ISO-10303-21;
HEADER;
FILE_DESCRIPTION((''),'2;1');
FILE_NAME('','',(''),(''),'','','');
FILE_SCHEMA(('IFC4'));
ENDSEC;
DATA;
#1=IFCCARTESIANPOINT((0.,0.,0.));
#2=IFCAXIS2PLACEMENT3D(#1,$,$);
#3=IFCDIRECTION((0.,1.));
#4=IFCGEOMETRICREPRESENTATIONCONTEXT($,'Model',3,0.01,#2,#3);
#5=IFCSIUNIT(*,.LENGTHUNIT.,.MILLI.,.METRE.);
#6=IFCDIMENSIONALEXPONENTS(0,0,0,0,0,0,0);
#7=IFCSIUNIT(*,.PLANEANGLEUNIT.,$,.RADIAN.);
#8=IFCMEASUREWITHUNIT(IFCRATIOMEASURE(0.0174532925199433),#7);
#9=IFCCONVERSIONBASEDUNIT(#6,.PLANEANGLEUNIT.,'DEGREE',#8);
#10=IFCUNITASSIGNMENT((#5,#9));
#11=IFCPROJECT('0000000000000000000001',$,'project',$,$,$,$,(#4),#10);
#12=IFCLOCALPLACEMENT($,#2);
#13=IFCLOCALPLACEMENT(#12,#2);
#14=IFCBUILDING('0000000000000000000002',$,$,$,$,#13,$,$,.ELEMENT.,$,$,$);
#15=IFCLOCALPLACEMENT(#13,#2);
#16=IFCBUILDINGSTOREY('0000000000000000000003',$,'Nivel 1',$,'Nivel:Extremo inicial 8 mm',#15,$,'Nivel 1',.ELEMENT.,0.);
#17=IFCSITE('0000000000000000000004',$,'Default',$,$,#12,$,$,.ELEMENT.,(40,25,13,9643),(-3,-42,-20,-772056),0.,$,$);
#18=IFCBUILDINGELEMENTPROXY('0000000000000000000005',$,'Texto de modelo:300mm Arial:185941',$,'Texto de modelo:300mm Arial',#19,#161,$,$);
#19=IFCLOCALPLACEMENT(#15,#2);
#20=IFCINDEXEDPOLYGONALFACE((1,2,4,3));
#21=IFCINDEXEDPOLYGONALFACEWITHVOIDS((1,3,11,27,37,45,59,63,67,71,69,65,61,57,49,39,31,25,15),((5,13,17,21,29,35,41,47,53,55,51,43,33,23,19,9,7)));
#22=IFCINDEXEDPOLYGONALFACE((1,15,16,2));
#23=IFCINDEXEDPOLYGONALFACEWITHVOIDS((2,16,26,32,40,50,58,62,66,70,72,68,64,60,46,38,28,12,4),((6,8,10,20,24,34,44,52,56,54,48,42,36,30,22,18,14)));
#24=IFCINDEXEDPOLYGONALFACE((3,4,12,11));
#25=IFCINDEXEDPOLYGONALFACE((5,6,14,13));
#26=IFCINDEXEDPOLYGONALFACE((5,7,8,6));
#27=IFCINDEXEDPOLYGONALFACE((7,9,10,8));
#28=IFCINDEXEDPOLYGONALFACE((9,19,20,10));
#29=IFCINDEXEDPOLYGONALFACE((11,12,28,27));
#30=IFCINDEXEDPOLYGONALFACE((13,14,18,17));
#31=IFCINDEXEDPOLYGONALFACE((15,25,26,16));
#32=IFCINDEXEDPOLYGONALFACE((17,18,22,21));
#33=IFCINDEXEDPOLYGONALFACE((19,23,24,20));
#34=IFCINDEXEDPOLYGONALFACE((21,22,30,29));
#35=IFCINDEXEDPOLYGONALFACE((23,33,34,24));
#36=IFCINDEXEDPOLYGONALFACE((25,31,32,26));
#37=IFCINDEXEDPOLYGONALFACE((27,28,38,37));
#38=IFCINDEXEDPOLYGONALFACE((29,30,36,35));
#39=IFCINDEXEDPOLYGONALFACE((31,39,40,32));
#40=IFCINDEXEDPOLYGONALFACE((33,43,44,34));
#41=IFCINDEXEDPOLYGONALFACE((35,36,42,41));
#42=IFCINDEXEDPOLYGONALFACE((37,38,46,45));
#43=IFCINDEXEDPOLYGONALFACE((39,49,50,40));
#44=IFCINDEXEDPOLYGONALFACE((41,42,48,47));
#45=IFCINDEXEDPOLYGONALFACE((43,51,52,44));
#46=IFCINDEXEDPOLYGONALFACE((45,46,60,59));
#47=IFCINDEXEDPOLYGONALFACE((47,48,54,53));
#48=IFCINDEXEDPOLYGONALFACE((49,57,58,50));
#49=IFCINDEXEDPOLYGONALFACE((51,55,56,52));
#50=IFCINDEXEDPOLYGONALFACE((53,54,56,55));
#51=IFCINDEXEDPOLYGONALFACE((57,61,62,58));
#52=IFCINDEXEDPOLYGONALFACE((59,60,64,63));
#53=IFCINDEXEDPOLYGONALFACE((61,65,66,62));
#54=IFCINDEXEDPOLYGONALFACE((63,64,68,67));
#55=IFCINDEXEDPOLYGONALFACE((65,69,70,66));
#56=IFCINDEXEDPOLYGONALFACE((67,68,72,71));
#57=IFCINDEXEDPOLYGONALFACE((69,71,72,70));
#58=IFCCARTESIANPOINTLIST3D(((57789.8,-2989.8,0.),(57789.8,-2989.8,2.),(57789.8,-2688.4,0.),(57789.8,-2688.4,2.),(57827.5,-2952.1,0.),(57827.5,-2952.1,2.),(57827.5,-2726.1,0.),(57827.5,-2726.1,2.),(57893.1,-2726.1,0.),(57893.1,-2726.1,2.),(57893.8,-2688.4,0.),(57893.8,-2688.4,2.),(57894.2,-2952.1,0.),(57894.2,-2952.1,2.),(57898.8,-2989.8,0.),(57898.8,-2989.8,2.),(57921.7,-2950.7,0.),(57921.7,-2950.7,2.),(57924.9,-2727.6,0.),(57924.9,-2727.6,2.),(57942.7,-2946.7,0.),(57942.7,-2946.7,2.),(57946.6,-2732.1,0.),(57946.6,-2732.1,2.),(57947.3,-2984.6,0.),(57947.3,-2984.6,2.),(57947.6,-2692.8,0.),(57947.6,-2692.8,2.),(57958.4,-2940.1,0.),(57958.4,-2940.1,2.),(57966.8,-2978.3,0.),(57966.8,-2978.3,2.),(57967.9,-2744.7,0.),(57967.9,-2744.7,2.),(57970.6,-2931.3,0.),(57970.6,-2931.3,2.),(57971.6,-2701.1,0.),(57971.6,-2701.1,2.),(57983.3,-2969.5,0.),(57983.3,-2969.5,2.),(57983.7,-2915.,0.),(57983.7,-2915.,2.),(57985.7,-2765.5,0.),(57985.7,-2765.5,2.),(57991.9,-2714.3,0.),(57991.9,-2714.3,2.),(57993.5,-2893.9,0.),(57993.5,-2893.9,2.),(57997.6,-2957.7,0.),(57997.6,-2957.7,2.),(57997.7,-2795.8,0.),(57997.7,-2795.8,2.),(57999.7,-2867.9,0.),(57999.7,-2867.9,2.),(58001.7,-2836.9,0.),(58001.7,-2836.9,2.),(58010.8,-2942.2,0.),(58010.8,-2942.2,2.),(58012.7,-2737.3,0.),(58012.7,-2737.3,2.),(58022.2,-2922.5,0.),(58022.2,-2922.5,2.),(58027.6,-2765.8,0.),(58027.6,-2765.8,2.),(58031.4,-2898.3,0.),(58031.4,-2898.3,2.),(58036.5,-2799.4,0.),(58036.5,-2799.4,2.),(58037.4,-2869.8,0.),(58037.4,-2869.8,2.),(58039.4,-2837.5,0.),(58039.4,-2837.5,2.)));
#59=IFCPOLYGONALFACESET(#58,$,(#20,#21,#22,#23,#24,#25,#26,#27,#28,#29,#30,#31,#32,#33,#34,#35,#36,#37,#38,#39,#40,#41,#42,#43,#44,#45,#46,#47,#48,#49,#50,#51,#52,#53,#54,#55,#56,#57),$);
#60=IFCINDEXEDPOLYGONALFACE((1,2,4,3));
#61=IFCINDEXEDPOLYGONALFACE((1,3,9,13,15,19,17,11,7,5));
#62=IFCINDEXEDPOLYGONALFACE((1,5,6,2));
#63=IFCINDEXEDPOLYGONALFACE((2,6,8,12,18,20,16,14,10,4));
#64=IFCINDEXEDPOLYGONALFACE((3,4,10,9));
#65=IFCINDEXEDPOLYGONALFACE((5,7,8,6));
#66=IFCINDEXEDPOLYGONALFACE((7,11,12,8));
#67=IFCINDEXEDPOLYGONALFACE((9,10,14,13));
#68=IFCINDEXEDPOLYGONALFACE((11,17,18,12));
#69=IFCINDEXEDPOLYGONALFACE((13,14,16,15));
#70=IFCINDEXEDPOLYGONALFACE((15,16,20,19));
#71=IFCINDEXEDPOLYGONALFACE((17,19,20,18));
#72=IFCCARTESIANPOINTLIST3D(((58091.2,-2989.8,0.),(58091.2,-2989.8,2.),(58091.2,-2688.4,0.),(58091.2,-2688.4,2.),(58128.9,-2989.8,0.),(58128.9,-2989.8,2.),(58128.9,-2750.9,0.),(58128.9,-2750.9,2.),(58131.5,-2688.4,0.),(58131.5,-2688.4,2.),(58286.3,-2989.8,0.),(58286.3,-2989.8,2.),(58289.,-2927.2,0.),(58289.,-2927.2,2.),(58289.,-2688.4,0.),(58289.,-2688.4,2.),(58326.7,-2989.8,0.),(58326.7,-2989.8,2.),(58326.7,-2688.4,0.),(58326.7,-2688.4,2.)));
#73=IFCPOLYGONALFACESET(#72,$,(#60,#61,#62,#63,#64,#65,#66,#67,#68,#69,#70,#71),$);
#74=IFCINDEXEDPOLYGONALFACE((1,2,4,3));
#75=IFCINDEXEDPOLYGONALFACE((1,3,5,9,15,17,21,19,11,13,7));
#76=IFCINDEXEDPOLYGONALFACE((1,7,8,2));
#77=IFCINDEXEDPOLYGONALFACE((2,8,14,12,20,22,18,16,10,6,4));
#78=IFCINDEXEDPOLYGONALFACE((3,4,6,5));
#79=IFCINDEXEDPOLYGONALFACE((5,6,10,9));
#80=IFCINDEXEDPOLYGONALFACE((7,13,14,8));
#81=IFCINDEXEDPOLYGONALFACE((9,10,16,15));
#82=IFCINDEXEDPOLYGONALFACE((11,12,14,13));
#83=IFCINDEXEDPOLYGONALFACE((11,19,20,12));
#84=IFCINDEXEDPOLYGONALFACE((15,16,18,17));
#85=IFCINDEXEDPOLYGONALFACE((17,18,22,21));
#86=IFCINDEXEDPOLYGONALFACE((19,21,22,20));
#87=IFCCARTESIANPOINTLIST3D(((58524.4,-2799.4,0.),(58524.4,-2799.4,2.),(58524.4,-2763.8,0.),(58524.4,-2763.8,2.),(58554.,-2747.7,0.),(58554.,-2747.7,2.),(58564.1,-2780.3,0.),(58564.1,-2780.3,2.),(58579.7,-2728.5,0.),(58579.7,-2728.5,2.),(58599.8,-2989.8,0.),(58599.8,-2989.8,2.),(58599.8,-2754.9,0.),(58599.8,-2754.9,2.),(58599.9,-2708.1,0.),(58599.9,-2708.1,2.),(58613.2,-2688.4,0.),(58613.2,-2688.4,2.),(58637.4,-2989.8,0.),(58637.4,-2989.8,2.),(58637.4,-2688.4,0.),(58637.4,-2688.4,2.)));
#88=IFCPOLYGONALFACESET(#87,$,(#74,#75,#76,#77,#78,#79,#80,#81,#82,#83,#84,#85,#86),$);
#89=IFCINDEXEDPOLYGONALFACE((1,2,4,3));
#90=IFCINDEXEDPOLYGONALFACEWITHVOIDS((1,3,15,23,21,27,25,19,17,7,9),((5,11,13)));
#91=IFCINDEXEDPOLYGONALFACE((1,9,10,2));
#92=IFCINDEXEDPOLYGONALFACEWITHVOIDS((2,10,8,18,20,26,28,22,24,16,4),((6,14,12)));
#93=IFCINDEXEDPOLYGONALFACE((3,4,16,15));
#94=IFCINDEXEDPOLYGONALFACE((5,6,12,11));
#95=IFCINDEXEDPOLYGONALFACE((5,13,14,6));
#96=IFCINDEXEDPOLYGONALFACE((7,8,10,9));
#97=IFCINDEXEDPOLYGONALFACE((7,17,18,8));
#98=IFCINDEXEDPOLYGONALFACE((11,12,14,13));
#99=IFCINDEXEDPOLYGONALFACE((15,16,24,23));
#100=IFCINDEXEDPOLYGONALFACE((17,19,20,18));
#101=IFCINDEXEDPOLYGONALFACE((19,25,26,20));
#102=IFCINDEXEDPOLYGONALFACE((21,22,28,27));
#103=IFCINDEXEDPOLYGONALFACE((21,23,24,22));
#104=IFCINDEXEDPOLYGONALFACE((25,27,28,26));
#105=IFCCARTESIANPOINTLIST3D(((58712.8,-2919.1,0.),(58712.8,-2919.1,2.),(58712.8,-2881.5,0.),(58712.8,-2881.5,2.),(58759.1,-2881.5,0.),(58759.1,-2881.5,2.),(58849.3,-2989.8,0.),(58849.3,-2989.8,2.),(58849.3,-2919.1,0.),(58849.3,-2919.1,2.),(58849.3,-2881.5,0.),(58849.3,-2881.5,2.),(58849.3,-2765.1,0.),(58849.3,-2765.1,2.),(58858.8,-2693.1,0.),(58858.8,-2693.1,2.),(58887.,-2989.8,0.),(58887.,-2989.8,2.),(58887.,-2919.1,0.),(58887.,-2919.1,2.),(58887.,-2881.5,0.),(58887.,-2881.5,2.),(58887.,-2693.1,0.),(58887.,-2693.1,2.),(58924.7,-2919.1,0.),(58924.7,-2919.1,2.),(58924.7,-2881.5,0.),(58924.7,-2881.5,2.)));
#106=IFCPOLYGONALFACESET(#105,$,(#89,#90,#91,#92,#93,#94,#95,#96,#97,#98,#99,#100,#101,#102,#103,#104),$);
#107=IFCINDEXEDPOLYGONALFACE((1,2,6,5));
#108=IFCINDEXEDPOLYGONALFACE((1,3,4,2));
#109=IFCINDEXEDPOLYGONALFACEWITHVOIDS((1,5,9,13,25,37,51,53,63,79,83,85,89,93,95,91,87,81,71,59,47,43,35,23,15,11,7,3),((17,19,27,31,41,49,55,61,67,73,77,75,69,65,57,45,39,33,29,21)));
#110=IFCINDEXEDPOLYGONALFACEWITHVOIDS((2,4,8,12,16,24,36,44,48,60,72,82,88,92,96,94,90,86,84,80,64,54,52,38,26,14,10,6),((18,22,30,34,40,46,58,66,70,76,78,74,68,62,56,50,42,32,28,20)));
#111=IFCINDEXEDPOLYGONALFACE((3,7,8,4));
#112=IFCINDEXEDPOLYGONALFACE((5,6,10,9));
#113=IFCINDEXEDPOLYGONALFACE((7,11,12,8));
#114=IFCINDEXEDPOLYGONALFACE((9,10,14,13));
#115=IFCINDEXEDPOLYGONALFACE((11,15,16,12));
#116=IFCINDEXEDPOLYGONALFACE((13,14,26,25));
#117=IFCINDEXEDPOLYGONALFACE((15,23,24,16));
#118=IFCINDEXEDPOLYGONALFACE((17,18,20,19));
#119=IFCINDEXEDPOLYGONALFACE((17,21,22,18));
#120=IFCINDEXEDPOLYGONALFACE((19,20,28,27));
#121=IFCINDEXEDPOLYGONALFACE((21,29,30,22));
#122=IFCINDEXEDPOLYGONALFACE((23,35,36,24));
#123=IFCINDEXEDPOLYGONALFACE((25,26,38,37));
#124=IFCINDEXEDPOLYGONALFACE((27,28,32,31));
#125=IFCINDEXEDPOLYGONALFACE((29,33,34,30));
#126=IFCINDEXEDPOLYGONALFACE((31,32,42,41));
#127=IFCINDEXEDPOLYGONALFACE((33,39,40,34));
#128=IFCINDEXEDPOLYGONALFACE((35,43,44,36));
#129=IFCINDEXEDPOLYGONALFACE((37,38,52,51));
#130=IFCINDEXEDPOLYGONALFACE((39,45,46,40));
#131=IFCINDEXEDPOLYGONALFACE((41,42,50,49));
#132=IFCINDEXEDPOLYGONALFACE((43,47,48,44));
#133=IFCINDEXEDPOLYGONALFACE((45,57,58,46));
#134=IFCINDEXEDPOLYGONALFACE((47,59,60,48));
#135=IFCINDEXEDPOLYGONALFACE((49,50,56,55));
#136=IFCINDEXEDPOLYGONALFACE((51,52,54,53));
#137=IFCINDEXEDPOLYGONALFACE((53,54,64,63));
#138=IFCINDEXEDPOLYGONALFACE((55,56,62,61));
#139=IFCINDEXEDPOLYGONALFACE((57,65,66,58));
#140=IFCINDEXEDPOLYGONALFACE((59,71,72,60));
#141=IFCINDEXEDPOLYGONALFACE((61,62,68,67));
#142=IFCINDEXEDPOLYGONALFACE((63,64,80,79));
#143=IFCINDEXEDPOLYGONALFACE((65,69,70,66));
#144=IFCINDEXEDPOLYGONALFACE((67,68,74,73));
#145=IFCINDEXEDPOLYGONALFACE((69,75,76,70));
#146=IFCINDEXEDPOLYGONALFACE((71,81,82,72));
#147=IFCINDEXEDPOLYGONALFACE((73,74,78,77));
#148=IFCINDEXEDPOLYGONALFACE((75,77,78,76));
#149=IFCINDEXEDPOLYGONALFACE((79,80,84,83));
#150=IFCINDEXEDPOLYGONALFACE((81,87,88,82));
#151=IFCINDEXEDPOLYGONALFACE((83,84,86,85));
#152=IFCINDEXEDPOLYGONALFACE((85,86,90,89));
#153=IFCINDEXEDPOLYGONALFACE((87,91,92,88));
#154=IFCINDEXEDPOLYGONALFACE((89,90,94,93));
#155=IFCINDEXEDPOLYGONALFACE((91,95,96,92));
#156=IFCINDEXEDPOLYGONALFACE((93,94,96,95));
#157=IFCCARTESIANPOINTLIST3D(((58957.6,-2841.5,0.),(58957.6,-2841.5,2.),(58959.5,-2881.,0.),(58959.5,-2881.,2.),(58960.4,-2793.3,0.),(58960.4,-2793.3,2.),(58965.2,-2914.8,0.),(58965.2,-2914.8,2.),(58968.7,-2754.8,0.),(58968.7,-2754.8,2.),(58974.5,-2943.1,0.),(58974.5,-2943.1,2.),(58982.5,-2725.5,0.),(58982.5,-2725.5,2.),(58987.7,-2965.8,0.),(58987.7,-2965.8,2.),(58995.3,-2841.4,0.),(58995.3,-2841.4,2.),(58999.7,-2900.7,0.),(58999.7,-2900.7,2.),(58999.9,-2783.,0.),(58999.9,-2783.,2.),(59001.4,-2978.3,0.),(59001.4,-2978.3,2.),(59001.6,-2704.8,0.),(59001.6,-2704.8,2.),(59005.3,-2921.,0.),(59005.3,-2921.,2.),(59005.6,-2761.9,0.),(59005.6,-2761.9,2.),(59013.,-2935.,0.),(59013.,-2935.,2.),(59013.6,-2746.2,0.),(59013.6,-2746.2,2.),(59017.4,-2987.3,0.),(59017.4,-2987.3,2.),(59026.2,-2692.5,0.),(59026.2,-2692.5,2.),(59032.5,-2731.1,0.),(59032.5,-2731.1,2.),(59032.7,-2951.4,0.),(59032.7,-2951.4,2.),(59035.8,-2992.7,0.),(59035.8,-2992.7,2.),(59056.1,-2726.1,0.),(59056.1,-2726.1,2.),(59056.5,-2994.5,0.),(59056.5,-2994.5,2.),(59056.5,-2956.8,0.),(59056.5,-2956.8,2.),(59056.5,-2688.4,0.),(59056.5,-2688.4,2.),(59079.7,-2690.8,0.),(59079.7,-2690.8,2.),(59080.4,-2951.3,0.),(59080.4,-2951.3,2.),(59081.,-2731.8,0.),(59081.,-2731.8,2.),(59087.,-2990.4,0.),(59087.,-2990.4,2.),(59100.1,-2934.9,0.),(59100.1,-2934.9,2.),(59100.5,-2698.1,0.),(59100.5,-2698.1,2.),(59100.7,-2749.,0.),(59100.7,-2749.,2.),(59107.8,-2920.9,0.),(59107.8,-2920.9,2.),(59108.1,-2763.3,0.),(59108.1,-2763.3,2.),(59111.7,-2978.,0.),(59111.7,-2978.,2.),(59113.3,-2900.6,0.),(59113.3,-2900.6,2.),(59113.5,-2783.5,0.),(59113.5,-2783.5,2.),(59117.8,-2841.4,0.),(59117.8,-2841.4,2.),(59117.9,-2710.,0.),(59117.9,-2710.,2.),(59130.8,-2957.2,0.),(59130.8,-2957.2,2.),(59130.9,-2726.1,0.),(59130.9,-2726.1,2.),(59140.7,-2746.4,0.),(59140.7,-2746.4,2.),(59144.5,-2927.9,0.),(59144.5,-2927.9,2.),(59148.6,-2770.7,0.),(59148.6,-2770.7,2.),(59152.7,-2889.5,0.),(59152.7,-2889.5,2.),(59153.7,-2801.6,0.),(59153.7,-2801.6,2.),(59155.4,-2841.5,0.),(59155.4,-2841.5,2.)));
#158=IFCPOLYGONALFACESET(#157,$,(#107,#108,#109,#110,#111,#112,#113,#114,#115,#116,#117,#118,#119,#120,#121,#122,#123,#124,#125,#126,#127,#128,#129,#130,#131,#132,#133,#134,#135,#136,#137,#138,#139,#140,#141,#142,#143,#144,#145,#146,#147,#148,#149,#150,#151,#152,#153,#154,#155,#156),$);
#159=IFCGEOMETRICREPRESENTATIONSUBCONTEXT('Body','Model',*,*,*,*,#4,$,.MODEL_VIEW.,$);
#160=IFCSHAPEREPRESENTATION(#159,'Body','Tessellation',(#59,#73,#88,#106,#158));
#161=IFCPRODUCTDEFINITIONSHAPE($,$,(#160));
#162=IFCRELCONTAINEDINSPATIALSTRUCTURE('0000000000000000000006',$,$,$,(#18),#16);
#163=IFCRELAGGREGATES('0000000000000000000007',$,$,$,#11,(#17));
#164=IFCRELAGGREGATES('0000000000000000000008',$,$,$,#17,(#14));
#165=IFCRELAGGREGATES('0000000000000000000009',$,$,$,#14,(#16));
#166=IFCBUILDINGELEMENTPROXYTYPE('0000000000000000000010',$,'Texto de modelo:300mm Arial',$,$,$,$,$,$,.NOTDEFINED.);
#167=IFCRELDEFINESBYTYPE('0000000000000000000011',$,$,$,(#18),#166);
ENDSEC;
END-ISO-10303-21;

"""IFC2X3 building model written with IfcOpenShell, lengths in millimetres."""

from ifc_helpers import new_model, entity, si_unit, converted_unit, direction, frame, origin, place, context, subcontext, project, spatial, polyline, outline, extrude, type_object, element, save


model = new_model("IFC2X3")

# Units and contexts
model_context = context("Model", 3, precision=0.01, world=origin(), true_north=direction((0.0, 1.0)))
body_context = subcontext(model_context, "Body", "Model", "MODEL_VIEW")
ifc_project = project(units=[si_unit("LENGTHUNIT", "METRE", prefix="MILLI"), converted_unit("PLANEANGLEUNIT", "DEGREE", entity("IfcRatioMeasure", 0.0174532925199433), si_unit("PLANEANGLEUNIT", "RADIAN"), dimensions=[0, 0, 0, 0, 0, 0, 0])], contexts=[model_context])

# Site, building, storey
site_placement = place(None, origin())
site = spatial("IfcSite", under=ifc_project, at=site_placement, Name="Default", CompositionType="ELEMENT", RefLatitude=(40, 25, 13, 9643), RefLongitude=(-3, -42, -20, -772056), RefElevation=0.0)
building_placement = place(site_placement, origin())
building = spatial("IfcBuilding", under=site, at=building_placement, CompositionType="ELEMENT")
storey_placement = place(building_placement, origin())
storey = spatial("IfcBuildingStorey", under=building, at=storey_placement, Name="Nivel 1", ObjectType="Nivel:Extremo inicial 8 mm", LongName="Nivel 1", CompositionType="ELEMENT", Elevation=0.0)

# Building element proxy
building_element_proxy_type_1 = type_object("IfcBuildingElementProxyType", Name="Texto de modelo:300mm Arial", PredefinedType="NOTDEFINED")
proxy_1_placement = place(storey_placement, frame((57789.8, -2994.5, 0.0)))
element("IfcBuildingElementProxy", 1, at=proxy_1_placement, inside=storey, type_object=building_element_proxy_type_1, Name="Texto de modelo:300mm Arial:185941", ObjectType="Texto de modelo:300mm Arial", context=body_context, shape_type="SweptSolid", body=[
    extrude(outline(polyline([(-178.4, -141.0), (-69.4, -141.0), (-21.0, -135.8), (-1.4, -129.5), (15.0, -120.7), (29.4, -108.9), (42.6, -93.4), (54.0, -73.7), (63.2, -49.5), (69.2, -21.0), (71.2, 11.3), (68.2, 49.4), (59.3, 83.0), (44.5, 111.5), (23.7, 134.5), (3.4, 147.7), (-20.6, 156.1), (-74.4, 160.4), (-178.4, 160.4), (-178.4, -141.0)]), holes=[polyline([(-140.7, -103.3), (-140.7, 122.7), (-75.1, 122.7), (-43.3, 121.2), (-21.7, 116.7), (-0.4, 104.1), (17.4, 83.3), (29.5, 53.0), (33.5, 11.9), (31.5, -19.1), (25.3, -45.1), (15.5, -66.2), (2.4, -82.5), (-9.8, -91.3), (-25.6, -97.9), (-46.5, -101.9), (-74.1, -103.3), (-140.7, -103.3)])]), frame((178.4, 145.7, 0.0)), (0.0, 0.0, 1.0), 2.0),
    extrude(outline(polyline([(-117.7, -150.7), (-80.1, -150.7), (-80.1, 88.1), (77.4, -150.7), (117.7, -150.7), (117.7, 150.7), (80.1, 150.7), (80.1, -88.1), (-77.4, 150.7), (-117.7, 150.7), (-117.7, -150.7)])), frame((419.1, 155.4, 0.0)), (0.0, 0.0, 1.0), 2.0),
    extrude(outline(polyline([(-204.4, -52.5), (97.0, -52.5), (97.0, -28.2), (77.2, -14.9), (56.9, 5.3), (37.7, 30.9), (21.6, 60.5), (-14.0, 60.5), (5.0, 20.8), (30.4, -14.9), (-204.4, -14.9), (-204.4, -52.5)])), frame((795.1, 209.1, 0.0), z_axis=(0.0, 0.0, 1.0), x_axis=(0.0, 1.0, 0.0)), (0.0, 0.0, 1.0), 2.0),
    extrude(outline(polyline([(-3.4, -109.2), (34.2, -109.2), (34.2, -38.5), (71.9, -38.5), (71.9, -0.9), (34.2, -0.9), (34.2, 187.5), (6.0, 187.5), (-140.0, -0.9), (-140.0, -38.5), (-3.4, -38.5), (-3.4, -109.2)]), holes=[polyline([(-3.4, -0.9), (-93.6, -0.9), (-3.4, 115.5), (-3.4, -0.9)])]), frame((1062.9, 113.9, 0.0)), (0.0, 0.0, 1.0), 2.0),
    extrude(outline(polyline([(-5.6, -99.5), (33.9, -99.5), (68.0, -95.5), (96.7, -87.5), (120.0, -75.5), (133.2, -62.4), (142.9, -46.8), (149.1, -28.7), (151.9, -8.0), (149.2, 22.6), (138.0, 47.8), (118.2, 67.9), (89.5, 82.9), (51.6, 93.0), (3.8, 98.0), (-36.2, 98.2), (-67.3, 94.5), (-91.9, 87.9), (-112.6, 79.0), (-129.4, 66.8), (-142.0, 50.0), (-150.3, 29.6), (-153.8, 6.5), (-151.2, -23.9), (-140.1, -49.1), (-120.3, -69.2), (-91.7, -84.4), (-53.6, -94.5), (-5.6, -99.5)]), holes=[polyline([(-3.9, -61.9), (-62.1, -54.6), (-82.9, -47.9), (-98.1, -39.2), (-112.3, -19.5), (-116.2, 4.3), (-109.3, 28.9), (-91.2, 47.7), (-76.5, 54.5), (-56.1, 58.9), (1.9, 60.4), (60.8, 53.2), (80.8, 46.7), (94.5, 38.3), (109.9, 17.8), (114.3, -6.3), (107.7, -29.8), (90.4, -48.7), (76.0, -55.8), (55.5, -60.3), (-3.9, -61.9)])]), frame((1267.5, 152.1, 0.0), z_axis=(0.0, 0.0, 1.0), x_axis=(0.047515, -0.998871, 0.0)), (0.0, 0.0, 1.0), 2.0),
])

save(model, "model.ifc")
